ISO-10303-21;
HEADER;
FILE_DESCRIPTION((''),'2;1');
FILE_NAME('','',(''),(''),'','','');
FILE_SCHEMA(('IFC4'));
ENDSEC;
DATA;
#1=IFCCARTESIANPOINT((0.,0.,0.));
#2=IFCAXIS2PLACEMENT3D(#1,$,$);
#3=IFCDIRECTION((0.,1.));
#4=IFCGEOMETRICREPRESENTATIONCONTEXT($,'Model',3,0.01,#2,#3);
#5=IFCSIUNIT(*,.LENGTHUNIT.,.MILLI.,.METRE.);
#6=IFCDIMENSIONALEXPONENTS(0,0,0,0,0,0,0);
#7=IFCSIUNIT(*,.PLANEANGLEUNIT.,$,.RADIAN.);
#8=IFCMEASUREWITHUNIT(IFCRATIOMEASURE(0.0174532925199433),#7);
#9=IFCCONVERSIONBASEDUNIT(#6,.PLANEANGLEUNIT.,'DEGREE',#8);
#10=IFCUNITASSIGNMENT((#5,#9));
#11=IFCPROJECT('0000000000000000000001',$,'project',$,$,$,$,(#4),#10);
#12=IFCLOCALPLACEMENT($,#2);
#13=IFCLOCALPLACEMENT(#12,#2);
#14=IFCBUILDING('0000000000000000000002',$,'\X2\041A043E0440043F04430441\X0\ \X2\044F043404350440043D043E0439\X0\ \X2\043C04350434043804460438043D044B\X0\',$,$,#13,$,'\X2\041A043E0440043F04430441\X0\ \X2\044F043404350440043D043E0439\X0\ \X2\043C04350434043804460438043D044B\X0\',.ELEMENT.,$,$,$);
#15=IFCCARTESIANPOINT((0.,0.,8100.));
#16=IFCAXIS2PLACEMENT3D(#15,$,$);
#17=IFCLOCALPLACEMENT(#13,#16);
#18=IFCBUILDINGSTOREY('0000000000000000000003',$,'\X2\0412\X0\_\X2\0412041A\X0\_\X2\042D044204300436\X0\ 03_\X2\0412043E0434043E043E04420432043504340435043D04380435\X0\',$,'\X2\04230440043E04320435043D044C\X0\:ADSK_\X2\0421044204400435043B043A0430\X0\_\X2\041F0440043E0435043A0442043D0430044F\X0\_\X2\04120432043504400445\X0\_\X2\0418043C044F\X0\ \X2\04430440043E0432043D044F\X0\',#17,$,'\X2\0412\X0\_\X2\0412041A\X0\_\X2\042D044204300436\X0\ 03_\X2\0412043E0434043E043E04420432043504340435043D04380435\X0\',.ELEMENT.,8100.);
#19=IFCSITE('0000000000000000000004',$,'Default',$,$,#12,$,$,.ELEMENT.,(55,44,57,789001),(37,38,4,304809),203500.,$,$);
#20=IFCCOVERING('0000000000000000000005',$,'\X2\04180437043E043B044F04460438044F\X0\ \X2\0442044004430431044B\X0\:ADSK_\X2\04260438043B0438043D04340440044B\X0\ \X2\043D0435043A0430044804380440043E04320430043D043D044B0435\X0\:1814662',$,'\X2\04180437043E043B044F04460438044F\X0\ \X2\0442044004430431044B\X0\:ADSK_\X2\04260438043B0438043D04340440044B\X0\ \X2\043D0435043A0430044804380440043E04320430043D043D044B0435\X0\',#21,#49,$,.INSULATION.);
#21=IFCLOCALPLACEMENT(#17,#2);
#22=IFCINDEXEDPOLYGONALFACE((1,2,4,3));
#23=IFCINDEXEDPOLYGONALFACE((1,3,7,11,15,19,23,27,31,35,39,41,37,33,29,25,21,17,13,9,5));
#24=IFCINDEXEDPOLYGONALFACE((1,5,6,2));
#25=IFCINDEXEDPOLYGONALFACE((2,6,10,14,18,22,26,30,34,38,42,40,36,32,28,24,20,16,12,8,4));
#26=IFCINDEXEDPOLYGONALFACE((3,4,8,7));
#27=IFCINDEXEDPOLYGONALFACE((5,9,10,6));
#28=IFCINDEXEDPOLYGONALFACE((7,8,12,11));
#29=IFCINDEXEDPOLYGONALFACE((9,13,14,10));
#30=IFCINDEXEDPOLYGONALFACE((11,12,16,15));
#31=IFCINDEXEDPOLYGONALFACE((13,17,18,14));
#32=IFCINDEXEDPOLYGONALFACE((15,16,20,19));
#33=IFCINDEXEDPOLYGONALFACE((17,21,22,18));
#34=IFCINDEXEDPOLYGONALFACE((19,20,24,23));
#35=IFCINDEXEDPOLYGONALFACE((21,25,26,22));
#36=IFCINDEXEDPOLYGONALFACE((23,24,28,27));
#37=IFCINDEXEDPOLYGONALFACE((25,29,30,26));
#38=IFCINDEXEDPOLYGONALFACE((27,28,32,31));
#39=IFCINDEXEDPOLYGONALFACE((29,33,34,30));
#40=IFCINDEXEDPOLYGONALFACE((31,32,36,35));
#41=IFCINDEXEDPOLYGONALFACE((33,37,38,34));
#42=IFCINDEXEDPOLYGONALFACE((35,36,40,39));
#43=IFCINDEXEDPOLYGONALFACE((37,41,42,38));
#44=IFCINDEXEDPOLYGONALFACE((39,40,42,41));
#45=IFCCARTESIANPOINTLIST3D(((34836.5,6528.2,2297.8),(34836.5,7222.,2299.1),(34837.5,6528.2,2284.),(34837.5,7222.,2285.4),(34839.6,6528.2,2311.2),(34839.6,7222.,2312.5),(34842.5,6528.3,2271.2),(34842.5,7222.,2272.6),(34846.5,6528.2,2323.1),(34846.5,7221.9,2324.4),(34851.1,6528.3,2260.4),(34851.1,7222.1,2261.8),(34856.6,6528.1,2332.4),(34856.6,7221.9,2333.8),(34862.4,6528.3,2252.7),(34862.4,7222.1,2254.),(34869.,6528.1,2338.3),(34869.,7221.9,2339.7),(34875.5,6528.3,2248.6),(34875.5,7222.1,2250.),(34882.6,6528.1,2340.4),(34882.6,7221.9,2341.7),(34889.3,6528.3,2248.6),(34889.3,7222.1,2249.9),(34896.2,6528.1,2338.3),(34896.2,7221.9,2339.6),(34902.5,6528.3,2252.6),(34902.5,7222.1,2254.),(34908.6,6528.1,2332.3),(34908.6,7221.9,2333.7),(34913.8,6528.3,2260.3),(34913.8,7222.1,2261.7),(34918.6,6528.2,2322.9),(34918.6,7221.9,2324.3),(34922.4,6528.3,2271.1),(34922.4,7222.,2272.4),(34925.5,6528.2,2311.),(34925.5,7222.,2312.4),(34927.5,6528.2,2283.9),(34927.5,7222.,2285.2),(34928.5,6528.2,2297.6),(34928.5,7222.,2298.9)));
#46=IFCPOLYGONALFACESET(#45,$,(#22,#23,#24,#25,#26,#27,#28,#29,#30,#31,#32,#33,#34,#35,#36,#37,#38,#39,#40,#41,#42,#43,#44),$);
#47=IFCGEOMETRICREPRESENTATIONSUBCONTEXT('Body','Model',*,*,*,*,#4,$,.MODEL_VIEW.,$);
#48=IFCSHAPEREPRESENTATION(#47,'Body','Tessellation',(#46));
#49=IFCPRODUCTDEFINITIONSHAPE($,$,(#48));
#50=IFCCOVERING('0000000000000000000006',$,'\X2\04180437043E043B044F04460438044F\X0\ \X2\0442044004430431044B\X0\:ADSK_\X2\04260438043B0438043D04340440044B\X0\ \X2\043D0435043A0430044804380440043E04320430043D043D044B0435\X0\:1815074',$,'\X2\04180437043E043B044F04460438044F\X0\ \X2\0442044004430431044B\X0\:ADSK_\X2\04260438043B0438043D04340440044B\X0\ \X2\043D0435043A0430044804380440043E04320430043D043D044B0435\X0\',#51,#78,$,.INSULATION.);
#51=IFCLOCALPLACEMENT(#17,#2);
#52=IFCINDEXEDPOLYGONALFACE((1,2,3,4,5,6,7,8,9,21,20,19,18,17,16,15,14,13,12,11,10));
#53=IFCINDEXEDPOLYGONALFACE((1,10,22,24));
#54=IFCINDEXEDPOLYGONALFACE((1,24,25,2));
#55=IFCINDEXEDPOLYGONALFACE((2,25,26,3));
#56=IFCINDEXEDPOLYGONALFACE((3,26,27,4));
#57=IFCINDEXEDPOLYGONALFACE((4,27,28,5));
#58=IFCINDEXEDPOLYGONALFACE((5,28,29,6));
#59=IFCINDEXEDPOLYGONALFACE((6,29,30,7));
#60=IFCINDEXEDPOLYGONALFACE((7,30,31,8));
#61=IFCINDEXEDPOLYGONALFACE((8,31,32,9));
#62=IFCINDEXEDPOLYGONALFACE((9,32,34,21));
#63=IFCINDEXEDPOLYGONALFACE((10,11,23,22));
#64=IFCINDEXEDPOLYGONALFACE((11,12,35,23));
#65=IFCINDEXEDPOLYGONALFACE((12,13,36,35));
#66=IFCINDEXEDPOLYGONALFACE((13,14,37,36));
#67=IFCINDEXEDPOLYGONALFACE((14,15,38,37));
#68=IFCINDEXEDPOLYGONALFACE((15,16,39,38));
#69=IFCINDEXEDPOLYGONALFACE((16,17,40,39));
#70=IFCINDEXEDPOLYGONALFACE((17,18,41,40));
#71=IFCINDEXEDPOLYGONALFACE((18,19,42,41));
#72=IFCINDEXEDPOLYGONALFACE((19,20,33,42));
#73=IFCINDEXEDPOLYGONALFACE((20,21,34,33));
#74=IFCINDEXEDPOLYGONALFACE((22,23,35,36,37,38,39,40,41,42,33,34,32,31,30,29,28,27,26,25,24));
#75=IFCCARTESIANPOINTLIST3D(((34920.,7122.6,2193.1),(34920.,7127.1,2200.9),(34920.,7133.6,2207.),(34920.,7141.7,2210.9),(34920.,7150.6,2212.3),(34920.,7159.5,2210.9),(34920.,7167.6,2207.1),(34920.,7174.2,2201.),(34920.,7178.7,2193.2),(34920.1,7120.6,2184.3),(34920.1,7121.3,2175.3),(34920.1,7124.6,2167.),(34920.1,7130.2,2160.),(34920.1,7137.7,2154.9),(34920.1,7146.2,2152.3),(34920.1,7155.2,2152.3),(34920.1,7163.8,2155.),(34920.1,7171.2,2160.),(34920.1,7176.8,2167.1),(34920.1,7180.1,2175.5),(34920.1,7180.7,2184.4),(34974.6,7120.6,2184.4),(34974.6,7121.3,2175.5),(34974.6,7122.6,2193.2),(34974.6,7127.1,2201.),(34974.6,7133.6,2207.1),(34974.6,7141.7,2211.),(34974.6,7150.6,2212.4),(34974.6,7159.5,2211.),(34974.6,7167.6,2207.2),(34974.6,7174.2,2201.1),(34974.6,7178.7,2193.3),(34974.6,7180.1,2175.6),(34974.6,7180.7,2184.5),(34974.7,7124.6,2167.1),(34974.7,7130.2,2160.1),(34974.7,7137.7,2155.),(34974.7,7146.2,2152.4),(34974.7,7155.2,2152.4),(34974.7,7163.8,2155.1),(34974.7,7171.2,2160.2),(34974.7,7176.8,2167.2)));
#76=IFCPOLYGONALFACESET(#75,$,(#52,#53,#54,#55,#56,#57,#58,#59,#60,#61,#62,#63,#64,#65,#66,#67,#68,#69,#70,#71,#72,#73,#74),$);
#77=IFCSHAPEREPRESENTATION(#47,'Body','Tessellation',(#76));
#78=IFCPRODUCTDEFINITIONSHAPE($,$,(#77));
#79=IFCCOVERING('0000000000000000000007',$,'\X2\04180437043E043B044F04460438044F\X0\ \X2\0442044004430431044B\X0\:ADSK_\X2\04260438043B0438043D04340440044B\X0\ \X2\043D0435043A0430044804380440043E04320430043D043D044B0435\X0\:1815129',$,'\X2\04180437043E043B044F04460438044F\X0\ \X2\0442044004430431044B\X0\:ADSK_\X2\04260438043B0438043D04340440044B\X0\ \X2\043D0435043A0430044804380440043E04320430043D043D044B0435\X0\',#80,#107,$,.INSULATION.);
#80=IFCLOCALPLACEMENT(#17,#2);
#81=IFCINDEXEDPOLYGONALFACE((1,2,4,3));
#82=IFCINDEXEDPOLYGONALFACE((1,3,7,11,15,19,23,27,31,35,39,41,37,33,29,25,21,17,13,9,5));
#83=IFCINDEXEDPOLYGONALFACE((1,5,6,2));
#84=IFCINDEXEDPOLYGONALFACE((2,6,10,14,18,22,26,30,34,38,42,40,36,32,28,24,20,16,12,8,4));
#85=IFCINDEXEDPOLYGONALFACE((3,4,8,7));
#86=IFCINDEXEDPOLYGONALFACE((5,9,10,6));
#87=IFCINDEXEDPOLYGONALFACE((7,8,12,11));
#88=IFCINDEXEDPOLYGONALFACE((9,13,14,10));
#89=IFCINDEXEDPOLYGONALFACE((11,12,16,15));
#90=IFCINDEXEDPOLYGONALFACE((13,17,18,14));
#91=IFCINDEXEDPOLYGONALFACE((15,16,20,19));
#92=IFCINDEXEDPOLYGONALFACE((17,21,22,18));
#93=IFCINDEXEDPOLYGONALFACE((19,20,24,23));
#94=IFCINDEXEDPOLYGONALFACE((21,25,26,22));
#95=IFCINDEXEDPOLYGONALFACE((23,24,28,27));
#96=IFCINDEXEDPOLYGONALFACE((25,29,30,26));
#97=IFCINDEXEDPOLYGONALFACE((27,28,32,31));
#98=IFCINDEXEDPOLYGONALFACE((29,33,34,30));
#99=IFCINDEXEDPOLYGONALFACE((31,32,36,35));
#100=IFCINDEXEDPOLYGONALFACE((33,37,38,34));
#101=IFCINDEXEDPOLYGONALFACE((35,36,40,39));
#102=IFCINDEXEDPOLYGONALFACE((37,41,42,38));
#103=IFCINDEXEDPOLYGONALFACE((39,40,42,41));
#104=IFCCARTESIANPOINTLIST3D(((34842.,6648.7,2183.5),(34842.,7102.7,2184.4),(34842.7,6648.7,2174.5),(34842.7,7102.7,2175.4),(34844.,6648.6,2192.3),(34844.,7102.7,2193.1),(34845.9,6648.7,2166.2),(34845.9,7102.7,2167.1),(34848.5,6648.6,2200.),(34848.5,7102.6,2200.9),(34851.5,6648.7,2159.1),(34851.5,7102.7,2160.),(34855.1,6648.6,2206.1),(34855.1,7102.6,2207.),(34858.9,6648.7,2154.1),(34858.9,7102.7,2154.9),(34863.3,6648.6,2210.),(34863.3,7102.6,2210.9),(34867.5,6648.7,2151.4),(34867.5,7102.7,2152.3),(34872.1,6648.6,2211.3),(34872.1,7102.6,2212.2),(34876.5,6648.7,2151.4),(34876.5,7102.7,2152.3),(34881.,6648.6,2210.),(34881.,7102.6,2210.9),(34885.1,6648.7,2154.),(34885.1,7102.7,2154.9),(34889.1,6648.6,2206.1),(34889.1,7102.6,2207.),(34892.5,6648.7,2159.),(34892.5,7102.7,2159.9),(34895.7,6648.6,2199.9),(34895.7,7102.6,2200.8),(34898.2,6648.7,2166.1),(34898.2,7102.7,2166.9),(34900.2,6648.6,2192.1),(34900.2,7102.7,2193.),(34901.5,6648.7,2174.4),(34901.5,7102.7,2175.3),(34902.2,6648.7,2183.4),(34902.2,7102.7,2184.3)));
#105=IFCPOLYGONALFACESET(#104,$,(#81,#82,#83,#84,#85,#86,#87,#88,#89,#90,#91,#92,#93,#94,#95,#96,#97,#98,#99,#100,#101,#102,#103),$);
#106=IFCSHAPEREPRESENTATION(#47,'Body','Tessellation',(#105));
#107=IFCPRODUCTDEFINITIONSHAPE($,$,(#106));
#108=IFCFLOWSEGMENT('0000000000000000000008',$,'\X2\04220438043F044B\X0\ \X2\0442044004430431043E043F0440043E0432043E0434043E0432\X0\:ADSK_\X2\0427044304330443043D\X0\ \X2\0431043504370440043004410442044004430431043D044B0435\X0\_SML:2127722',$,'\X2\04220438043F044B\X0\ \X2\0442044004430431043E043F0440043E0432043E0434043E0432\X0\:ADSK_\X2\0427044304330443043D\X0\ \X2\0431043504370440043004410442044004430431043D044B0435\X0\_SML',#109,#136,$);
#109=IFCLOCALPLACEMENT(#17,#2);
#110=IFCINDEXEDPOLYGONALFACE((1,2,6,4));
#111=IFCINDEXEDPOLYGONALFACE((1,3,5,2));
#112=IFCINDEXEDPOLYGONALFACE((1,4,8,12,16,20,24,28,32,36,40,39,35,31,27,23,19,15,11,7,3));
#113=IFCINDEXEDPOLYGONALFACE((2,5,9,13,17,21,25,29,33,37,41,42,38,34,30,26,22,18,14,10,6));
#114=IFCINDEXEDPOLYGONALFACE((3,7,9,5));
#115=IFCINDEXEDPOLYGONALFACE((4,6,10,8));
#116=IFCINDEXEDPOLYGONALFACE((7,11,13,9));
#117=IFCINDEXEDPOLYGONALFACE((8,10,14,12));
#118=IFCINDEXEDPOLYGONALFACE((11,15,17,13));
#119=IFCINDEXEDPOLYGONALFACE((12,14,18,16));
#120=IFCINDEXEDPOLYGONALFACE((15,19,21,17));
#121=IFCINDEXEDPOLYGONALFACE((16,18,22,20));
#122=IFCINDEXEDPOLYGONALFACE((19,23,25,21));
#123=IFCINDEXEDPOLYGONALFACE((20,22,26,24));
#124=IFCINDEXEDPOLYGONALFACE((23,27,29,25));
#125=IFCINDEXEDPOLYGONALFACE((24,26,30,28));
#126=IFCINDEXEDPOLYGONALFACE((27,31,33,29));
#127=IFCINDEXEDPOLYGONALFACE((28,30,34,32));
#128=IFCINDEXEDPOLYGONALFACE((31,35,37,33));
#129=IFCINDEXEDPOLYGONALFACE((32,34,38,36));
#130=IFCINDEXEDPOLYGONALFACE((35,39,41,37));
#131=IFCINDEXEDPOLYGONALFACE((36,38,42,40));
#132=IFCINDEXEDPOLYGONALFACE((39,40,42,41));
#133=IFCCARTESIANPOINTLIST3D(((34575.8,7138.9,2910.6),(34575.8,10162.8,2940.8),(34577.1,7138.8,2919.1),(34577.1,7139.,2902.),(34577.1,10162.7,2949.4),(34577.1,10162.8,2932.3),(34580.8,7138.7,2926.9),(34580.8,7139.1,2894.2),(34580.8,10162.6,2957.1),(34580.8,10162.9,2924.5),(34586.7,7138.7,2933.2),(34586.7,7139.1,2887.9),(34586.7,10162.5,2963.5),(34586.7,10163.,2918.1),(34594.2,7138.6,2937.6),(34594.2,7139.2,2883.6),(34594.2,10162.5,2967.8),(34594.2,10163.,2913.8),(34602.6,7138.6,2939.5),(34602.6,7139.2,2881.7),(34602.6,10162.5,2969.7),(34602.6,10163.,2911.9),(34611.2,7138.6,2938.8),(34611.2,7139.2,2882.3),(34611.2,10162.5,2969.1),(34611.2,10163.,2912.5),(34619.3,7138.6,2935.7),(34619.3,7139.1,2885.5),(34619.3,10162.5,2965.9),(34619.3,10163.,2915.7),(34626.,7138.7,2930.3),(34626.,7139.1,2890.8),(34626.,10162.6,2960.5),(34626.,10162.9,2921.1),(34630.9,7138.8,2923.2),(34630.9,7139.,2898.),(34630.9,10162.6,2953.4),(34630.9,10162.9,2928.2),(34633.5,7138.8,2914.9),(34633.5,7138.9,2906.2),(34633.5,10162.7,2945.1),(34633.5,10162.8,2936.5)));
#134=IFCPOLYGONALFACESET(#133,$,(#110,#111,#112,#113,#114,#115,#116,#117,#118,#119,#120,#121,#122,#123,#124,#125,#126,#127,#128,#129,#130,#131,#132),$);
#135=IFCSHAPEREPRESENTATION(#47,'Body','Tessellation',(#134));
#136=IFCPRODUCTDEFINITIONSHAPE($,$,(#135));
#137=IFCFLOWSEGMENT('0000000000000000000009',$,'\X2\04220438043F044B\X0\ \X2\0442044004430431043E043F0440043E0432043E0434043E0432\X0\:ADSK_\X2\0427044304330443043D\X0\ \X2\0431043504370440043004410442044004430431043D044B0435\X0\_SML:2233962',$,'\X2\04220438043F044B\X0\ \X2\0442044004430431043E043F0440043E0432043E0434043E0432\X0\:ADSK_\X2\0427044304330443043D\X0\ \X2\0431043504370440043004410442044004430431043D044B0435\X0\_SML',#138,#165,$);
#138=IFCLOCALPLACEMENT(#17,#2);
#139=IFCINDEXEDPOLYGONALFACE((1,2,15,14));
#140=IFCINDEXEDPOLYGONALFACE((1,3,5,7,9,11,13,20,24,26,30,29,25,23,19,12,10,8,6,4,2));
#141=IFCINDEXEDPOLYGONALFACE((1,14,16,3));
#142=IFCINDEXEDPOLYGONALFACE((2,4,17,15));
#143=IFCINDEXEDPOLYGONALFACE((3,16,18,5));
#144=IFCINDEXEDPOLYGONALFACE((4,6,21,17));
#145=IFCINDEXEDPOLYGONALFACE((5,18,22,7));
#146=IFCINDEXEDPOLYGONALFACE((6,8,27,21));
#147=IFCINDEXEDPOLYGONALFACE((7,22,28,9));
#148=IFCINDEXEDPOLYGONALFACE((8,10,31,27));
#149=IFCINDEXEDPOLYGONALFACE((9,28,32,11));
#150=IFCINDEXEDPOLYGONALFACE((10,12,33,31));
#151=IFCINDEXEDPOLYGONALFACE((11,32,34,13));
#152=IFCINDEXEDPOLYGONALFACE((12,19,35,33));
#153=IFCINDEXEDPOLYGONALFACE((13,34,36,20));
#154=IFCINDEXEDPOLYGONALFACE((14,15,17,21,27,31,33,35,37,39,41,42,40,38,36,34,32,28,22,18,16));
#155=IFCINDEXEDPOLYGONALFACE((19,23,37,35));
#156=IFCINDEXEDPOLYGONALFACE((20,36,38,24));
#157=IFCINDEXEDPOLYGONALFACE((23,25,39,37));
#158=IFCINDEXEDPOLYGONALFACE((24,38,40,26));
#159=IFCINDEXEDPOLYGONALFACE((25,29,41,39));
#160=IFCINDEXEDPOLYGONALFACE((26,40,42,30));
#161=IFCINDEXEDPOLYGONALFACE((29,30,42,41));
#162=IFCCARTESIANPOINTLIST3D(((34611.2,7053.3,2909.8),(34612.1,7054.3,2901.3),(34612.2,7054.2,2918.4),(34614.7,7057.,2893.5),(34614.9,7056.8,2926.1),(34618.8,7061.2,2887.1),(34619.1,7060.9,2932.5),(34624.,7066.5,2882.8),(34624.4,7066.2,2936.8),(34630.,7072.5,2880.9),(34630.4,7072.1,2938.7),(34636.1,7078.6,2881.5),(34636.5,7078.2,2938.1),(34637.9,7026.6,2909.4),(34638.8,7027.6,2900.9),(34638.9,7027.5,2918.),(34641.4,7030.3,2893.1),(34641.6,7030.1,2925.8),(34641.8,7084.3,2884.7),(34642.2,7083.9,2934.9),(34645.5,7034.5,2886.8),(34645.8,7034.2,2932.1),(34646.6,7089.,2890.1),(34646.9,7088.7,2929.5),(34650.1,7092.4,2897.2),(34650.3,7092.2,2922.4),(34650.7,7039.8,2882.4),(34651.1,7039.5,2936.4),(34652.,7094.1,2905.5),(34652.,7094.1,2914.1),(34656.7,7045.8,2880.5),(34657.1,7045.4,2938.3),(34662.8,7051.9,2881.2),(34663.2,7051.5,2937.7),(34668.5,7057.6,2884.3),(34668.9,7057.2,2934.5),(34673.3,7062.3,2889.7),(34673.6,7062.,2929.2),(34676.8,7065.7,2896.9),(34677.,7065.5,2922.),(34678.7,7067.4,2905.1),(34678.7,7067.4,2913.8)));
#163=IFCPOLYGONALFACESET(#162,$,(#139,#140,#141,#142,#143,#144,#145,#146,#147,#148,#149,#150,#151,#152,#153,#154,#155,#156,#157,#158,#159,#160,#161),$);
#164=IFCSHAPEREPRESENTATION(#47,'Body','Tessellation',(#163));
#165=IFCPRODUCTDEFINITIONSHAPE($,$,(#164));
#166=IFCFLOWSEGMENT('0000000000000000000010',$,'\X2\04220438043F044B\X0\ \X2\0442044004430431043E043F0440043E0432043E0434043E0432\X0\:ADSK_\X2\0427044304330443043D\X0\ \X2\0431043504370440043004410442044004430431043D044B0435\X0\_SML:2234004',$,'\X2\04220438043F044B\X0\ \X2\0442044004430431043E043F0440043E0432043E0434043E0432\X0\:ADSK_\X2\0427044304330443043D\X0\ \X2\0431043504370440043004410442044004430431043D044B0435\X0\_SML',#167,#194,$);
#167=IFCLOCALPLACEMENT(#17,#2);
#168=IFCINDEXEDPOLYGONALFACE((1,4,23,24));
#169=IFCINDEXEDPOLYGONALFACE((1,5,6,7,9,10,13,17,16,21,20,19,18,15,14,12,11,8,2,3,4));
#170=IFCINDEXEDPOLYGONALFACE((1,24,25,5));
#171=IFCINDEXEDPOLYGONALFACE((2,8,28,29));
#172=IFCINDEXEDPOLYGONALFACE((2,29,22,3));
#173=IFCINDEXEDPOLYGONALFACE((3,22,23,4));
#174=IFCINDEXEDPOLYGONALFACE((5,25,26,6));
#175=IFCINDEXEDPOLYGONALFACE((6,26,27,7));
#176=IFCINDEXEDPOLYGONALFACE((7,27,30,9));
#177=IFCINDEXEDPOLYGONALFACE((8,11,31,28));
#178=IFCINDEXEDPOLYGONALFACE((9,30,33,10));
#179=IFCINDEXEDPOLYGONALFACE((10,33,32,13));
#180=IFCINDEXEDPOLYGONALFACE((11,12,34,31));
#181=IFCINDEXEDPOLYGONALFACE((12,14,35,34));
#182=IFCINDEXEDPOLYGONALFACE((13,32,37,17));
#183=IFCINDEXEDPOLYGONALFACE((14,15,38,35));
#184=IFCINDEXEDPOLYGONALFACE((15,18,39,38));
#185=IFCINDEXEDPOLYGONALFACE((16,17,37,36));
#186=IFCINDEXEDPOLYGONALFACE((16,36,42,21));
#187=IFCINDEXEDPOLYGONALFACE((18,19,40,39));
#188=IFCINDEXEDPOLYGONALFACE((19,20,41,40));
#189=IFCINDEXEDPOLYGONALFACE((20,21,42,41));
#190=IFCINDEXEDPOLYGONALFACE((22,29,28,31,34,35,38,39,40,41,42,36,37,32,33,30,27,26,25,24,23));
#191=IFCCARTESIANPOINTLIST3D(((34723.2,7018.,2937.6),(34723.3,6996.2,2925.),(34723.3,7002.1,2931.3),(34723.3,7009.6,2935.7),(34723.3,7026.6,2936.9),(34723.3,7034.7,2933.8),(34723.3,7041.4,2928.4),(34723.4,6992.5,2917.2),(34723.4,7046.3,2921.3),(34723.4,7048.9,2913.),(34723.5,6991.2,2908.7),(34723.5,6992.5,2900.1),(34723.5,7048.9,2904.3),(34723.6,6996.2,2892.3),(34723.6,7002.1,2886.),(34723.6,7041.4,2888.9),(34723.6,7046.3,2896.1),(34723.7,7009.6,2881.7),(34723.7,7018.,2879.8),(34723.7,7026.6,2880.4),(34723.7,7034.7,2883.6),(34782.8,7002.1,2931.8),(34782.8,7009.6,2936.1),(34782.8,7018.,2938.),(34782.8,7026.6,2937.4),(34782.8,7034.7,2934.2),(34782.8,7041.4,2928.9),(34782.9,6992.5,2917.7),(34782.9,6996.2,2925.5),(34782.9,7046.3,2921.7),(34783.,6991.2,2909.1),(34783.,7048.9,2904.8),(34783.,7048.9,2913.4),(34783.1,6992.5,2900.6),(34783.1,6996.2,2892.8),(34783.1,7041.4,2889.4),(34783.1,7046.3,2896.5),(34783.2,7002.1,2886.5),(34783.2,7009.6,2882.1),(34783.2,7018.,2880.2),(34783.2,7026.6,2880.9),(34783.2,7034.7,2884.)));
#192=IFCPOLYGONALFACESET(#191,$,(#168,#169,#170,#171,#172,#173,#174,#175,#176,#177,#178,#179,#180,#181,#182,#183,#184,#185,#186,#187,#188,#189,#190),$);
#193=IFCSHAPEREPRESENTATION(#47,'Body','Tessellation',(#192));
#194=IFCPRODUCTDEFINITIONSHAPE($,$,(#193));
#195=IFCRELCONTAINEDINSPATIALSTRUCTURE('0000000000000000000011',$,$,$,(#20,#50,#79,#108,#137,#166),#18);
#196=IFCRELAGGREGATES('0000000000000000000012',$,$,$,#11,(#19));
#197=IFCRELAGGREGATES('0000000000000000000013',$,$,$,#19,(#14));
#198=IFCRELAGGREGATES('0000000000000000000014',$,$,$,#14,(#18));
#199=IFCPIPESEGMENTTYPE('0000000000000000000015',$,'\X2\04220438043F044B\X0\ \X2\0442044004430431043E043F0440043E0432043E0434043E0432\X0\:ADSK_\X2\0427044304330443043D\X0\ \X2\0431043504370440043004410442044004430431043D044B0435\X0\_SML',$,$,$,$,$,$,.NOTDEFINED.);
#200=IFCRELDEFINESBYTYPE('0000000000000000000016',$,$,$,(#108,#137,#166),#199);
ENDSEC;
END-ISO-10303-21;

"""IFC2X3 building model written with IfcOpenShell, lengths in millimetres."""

from ifc_helpers import new_model, entity, si_unit, converted_unit, direction, frame, origin, origin_2d_with_axis, place, context, subcontext, project, spatial, circle, extrude, type_object, element, save


model = new_model("IFC2X3")

# Units and contexts
model_context = context("Model", 3, precision=0.01, world=origin(), true_north=direction((0.0, 1.0)))
body_context = subcontext(model_context, "Body", "Model", "MODEL_VIEW")
ifc_project = project(units=[si_unit("LENGTHUNIT", "METRE", prefix="MILLI"), converted_unit("PLANEANGLEUNIT", "DEGREE", entity("IfcRatioMeasure", 0.0174532925199433), si_unit("PLANEANGLEUNIT", "RADIAN"), dimensions=[0, 0, 0, 0, 0, 0, 0])], contexts=[model_context])

# Site, building, storey
site_placement = place(None, origin())
site = spatial("IfcSite", under=ifc_project, at=site_placement, Name="Default", CompositionType="ELEMENT", RefLatitude=(55, 44, 57, 789001), RefLongitude=(37, 38, 4, 304809), RefElevation=203500.0)
building_placement = place(site_placement, origin())
building = spatial("IfcBuilding", under=site, at=building_placement, Name="Корпус ядерной медицины", LongName="Корпус ядерной медицины", CompositionType="ELEMENT")
storey_placement = place(building_placement, frame((0.0, 0.0, 8100.0)))
storey = spatial("IfcBuildingStorey", under=building, at=storey_placement, Name="В_ВК_Этаж 03_Водоотведение", ObjectType="Уровень:ADSK_Стрелка_Проектная_Вверх_Имя уровня", LongName="В_ВК_Этаж 03_Водоотведение", CompositionType="ELEMENT", Elevation=8100.0)

# Coverings
covering_1_placement = place(storey_placement, frame((34834.8, 6528.1, 2246.5)))
element("IfcCovering", 1, at=covering_1_placement, inside=storey, Name="Изоляция трубы:ADSK_Цилиндры некашированные:1814662", ObjectType="Изоляция трубы:ADSK_Цилиндры некашированные", PredefinedType="INSULATION", context=body_context, shape_type="SweptSolid", body=[
    extrude(circle(Radius=46.1, at=origin_2d_with_axis()), frame((47.8, 0.1, 47.8), z_axis=(0.0, 0.999998, 0.001971), x_axis=(0.002, -0.001971, 0.999996)), (0.0, 0.0, 1.0), 693.8),
])
covering_2_placement = place(storey_placement, frame((34920.0, 7118.9, 2150.4)))
element("IfcCovering", 2, at=covering_2_placement, inside=storey, Name="Изоляция трубы:ADSK_Цилиндры некашированные:1815074", ObjectType="Изоляция трубы:ADSK_Цилиндры некашированные", PredefinedType="INSULATION", context=body_context, shape_type="SweptSolid", body=[
    extrude(circle(Radius=30.1, at=origin_2d_with_axis()), frame((0.1, 31.8, 31.8), z_axis=(0.999998, 0.0, 0.002), x_axis=(-0.002, -0.002, 0.999996)), (0.0, 0.0, 1.0), 54.6),
])
covering_3_placement = place(storey_placement, frame((34840.3, 6648.6, 2149.4)))
element("IfcCovering", 3, at=covering_3_placement, inside=storey, Name="Изоляция трубы:ADSK_Цилиндры некашированные:1815129", ObjectType="Изоляция трубы:ADSK_Цилиндры некашированные", PredefinedType="INSULATION", context=body_context, shape_type="SweptSolid", body=[
    extrude(circle(Radius=30.1, at=origin_2d_with_axis()), frame((31.8, 0.1, 31.8), z_axis=(0.0, 0.999998, 0.001945), x_axis=(0.002, -0.001945, 0.999996)), (0.0, 0.0, 1.0), 454.0),
])

# Flow segments
pipe_segment_type_1 = type_object("IfcPipeSegmentType", Name="Типы трубопроводов:ADSK_Чугун безраструбные_SML", PredefinedType="NOTDEFINED")
flow_segment_1_placement = place(storey_placement, frame((34574.2, 7137.0, 2880.0)))
element("IfcFlowSegment", 4, at=flow_segment_1_placement, inside=storey, type_object=pipe_segment_type_1, Name="Типы трубопроводов:ADSK_Чугун безраструбные_SML:2127722", ObjectType="Типы трубопроводов:ADSK_Чугун безраструбные_SML", context=body_context, shape_type="SweptSolid", body=[
    extrude(circle(Radius=29.0, at=origin_2d_with_axis()), frame((30.6, 1.9, 30.6), z_axis=(0.000003, 0.99995, 0.01), x_axis=(-1.0, 0.000003, 0.0)), (0.0, 0.0, 1.0), 3024.0),
])
flow_segment_2_placement = place(storey_placement, frame((34609.6, 7025.0, 2878.8)))
element("IfcFlowSegment", 5, at=flow_segment_2_placement, inside=storey, type_object=pipe_segment_type_1, Name="Типы трубопроводов:ADSK_Чугун безраструбные_SML:2233962", ObjectType="Типы трубопроводов:ADSK_Чугун безраструбные_SML", context=body_context, shape_type="SweptSolid", body=[
    extrude(circle(Radius=29.0, at=origin_2d_with_axis()), frame((22.1, 48.8, 31.0), z_axis=(0.707071, -0.707071, -0.01), x_axis=(-0.707107, -0.707107, 0.0)), (0.0, 0.0, 1.0), 37.8),
])
flow_segment_3_placement = place(storey_placement, frame((34721.7, 6989.6, 2878.1)))
element("IfcFlowSegment", 6, at=flow_segment_3_placement, inside=storey, type_object=pipe_segment_type_1, Name="Типы трубопроводов:ADSK_Чугун безраструбные_SML:2234004", ObjectType="Типы трубопроводов:ADSK_Чугун безраструбные_SML", context=body_context, shape_type="SweptSolid", body=[
    extrude(circle(Radius=29.0, at=origin_2d_with_axis()), frame((1.8, 30.6, 30.6), z_axis=(0.999971, 0.00001, 0.007657), x_axis=(0.00001, -1.0, 0.0)), (0.0, 0.0, 1.0), 59.5),
])

save(model, "model.ifc")
